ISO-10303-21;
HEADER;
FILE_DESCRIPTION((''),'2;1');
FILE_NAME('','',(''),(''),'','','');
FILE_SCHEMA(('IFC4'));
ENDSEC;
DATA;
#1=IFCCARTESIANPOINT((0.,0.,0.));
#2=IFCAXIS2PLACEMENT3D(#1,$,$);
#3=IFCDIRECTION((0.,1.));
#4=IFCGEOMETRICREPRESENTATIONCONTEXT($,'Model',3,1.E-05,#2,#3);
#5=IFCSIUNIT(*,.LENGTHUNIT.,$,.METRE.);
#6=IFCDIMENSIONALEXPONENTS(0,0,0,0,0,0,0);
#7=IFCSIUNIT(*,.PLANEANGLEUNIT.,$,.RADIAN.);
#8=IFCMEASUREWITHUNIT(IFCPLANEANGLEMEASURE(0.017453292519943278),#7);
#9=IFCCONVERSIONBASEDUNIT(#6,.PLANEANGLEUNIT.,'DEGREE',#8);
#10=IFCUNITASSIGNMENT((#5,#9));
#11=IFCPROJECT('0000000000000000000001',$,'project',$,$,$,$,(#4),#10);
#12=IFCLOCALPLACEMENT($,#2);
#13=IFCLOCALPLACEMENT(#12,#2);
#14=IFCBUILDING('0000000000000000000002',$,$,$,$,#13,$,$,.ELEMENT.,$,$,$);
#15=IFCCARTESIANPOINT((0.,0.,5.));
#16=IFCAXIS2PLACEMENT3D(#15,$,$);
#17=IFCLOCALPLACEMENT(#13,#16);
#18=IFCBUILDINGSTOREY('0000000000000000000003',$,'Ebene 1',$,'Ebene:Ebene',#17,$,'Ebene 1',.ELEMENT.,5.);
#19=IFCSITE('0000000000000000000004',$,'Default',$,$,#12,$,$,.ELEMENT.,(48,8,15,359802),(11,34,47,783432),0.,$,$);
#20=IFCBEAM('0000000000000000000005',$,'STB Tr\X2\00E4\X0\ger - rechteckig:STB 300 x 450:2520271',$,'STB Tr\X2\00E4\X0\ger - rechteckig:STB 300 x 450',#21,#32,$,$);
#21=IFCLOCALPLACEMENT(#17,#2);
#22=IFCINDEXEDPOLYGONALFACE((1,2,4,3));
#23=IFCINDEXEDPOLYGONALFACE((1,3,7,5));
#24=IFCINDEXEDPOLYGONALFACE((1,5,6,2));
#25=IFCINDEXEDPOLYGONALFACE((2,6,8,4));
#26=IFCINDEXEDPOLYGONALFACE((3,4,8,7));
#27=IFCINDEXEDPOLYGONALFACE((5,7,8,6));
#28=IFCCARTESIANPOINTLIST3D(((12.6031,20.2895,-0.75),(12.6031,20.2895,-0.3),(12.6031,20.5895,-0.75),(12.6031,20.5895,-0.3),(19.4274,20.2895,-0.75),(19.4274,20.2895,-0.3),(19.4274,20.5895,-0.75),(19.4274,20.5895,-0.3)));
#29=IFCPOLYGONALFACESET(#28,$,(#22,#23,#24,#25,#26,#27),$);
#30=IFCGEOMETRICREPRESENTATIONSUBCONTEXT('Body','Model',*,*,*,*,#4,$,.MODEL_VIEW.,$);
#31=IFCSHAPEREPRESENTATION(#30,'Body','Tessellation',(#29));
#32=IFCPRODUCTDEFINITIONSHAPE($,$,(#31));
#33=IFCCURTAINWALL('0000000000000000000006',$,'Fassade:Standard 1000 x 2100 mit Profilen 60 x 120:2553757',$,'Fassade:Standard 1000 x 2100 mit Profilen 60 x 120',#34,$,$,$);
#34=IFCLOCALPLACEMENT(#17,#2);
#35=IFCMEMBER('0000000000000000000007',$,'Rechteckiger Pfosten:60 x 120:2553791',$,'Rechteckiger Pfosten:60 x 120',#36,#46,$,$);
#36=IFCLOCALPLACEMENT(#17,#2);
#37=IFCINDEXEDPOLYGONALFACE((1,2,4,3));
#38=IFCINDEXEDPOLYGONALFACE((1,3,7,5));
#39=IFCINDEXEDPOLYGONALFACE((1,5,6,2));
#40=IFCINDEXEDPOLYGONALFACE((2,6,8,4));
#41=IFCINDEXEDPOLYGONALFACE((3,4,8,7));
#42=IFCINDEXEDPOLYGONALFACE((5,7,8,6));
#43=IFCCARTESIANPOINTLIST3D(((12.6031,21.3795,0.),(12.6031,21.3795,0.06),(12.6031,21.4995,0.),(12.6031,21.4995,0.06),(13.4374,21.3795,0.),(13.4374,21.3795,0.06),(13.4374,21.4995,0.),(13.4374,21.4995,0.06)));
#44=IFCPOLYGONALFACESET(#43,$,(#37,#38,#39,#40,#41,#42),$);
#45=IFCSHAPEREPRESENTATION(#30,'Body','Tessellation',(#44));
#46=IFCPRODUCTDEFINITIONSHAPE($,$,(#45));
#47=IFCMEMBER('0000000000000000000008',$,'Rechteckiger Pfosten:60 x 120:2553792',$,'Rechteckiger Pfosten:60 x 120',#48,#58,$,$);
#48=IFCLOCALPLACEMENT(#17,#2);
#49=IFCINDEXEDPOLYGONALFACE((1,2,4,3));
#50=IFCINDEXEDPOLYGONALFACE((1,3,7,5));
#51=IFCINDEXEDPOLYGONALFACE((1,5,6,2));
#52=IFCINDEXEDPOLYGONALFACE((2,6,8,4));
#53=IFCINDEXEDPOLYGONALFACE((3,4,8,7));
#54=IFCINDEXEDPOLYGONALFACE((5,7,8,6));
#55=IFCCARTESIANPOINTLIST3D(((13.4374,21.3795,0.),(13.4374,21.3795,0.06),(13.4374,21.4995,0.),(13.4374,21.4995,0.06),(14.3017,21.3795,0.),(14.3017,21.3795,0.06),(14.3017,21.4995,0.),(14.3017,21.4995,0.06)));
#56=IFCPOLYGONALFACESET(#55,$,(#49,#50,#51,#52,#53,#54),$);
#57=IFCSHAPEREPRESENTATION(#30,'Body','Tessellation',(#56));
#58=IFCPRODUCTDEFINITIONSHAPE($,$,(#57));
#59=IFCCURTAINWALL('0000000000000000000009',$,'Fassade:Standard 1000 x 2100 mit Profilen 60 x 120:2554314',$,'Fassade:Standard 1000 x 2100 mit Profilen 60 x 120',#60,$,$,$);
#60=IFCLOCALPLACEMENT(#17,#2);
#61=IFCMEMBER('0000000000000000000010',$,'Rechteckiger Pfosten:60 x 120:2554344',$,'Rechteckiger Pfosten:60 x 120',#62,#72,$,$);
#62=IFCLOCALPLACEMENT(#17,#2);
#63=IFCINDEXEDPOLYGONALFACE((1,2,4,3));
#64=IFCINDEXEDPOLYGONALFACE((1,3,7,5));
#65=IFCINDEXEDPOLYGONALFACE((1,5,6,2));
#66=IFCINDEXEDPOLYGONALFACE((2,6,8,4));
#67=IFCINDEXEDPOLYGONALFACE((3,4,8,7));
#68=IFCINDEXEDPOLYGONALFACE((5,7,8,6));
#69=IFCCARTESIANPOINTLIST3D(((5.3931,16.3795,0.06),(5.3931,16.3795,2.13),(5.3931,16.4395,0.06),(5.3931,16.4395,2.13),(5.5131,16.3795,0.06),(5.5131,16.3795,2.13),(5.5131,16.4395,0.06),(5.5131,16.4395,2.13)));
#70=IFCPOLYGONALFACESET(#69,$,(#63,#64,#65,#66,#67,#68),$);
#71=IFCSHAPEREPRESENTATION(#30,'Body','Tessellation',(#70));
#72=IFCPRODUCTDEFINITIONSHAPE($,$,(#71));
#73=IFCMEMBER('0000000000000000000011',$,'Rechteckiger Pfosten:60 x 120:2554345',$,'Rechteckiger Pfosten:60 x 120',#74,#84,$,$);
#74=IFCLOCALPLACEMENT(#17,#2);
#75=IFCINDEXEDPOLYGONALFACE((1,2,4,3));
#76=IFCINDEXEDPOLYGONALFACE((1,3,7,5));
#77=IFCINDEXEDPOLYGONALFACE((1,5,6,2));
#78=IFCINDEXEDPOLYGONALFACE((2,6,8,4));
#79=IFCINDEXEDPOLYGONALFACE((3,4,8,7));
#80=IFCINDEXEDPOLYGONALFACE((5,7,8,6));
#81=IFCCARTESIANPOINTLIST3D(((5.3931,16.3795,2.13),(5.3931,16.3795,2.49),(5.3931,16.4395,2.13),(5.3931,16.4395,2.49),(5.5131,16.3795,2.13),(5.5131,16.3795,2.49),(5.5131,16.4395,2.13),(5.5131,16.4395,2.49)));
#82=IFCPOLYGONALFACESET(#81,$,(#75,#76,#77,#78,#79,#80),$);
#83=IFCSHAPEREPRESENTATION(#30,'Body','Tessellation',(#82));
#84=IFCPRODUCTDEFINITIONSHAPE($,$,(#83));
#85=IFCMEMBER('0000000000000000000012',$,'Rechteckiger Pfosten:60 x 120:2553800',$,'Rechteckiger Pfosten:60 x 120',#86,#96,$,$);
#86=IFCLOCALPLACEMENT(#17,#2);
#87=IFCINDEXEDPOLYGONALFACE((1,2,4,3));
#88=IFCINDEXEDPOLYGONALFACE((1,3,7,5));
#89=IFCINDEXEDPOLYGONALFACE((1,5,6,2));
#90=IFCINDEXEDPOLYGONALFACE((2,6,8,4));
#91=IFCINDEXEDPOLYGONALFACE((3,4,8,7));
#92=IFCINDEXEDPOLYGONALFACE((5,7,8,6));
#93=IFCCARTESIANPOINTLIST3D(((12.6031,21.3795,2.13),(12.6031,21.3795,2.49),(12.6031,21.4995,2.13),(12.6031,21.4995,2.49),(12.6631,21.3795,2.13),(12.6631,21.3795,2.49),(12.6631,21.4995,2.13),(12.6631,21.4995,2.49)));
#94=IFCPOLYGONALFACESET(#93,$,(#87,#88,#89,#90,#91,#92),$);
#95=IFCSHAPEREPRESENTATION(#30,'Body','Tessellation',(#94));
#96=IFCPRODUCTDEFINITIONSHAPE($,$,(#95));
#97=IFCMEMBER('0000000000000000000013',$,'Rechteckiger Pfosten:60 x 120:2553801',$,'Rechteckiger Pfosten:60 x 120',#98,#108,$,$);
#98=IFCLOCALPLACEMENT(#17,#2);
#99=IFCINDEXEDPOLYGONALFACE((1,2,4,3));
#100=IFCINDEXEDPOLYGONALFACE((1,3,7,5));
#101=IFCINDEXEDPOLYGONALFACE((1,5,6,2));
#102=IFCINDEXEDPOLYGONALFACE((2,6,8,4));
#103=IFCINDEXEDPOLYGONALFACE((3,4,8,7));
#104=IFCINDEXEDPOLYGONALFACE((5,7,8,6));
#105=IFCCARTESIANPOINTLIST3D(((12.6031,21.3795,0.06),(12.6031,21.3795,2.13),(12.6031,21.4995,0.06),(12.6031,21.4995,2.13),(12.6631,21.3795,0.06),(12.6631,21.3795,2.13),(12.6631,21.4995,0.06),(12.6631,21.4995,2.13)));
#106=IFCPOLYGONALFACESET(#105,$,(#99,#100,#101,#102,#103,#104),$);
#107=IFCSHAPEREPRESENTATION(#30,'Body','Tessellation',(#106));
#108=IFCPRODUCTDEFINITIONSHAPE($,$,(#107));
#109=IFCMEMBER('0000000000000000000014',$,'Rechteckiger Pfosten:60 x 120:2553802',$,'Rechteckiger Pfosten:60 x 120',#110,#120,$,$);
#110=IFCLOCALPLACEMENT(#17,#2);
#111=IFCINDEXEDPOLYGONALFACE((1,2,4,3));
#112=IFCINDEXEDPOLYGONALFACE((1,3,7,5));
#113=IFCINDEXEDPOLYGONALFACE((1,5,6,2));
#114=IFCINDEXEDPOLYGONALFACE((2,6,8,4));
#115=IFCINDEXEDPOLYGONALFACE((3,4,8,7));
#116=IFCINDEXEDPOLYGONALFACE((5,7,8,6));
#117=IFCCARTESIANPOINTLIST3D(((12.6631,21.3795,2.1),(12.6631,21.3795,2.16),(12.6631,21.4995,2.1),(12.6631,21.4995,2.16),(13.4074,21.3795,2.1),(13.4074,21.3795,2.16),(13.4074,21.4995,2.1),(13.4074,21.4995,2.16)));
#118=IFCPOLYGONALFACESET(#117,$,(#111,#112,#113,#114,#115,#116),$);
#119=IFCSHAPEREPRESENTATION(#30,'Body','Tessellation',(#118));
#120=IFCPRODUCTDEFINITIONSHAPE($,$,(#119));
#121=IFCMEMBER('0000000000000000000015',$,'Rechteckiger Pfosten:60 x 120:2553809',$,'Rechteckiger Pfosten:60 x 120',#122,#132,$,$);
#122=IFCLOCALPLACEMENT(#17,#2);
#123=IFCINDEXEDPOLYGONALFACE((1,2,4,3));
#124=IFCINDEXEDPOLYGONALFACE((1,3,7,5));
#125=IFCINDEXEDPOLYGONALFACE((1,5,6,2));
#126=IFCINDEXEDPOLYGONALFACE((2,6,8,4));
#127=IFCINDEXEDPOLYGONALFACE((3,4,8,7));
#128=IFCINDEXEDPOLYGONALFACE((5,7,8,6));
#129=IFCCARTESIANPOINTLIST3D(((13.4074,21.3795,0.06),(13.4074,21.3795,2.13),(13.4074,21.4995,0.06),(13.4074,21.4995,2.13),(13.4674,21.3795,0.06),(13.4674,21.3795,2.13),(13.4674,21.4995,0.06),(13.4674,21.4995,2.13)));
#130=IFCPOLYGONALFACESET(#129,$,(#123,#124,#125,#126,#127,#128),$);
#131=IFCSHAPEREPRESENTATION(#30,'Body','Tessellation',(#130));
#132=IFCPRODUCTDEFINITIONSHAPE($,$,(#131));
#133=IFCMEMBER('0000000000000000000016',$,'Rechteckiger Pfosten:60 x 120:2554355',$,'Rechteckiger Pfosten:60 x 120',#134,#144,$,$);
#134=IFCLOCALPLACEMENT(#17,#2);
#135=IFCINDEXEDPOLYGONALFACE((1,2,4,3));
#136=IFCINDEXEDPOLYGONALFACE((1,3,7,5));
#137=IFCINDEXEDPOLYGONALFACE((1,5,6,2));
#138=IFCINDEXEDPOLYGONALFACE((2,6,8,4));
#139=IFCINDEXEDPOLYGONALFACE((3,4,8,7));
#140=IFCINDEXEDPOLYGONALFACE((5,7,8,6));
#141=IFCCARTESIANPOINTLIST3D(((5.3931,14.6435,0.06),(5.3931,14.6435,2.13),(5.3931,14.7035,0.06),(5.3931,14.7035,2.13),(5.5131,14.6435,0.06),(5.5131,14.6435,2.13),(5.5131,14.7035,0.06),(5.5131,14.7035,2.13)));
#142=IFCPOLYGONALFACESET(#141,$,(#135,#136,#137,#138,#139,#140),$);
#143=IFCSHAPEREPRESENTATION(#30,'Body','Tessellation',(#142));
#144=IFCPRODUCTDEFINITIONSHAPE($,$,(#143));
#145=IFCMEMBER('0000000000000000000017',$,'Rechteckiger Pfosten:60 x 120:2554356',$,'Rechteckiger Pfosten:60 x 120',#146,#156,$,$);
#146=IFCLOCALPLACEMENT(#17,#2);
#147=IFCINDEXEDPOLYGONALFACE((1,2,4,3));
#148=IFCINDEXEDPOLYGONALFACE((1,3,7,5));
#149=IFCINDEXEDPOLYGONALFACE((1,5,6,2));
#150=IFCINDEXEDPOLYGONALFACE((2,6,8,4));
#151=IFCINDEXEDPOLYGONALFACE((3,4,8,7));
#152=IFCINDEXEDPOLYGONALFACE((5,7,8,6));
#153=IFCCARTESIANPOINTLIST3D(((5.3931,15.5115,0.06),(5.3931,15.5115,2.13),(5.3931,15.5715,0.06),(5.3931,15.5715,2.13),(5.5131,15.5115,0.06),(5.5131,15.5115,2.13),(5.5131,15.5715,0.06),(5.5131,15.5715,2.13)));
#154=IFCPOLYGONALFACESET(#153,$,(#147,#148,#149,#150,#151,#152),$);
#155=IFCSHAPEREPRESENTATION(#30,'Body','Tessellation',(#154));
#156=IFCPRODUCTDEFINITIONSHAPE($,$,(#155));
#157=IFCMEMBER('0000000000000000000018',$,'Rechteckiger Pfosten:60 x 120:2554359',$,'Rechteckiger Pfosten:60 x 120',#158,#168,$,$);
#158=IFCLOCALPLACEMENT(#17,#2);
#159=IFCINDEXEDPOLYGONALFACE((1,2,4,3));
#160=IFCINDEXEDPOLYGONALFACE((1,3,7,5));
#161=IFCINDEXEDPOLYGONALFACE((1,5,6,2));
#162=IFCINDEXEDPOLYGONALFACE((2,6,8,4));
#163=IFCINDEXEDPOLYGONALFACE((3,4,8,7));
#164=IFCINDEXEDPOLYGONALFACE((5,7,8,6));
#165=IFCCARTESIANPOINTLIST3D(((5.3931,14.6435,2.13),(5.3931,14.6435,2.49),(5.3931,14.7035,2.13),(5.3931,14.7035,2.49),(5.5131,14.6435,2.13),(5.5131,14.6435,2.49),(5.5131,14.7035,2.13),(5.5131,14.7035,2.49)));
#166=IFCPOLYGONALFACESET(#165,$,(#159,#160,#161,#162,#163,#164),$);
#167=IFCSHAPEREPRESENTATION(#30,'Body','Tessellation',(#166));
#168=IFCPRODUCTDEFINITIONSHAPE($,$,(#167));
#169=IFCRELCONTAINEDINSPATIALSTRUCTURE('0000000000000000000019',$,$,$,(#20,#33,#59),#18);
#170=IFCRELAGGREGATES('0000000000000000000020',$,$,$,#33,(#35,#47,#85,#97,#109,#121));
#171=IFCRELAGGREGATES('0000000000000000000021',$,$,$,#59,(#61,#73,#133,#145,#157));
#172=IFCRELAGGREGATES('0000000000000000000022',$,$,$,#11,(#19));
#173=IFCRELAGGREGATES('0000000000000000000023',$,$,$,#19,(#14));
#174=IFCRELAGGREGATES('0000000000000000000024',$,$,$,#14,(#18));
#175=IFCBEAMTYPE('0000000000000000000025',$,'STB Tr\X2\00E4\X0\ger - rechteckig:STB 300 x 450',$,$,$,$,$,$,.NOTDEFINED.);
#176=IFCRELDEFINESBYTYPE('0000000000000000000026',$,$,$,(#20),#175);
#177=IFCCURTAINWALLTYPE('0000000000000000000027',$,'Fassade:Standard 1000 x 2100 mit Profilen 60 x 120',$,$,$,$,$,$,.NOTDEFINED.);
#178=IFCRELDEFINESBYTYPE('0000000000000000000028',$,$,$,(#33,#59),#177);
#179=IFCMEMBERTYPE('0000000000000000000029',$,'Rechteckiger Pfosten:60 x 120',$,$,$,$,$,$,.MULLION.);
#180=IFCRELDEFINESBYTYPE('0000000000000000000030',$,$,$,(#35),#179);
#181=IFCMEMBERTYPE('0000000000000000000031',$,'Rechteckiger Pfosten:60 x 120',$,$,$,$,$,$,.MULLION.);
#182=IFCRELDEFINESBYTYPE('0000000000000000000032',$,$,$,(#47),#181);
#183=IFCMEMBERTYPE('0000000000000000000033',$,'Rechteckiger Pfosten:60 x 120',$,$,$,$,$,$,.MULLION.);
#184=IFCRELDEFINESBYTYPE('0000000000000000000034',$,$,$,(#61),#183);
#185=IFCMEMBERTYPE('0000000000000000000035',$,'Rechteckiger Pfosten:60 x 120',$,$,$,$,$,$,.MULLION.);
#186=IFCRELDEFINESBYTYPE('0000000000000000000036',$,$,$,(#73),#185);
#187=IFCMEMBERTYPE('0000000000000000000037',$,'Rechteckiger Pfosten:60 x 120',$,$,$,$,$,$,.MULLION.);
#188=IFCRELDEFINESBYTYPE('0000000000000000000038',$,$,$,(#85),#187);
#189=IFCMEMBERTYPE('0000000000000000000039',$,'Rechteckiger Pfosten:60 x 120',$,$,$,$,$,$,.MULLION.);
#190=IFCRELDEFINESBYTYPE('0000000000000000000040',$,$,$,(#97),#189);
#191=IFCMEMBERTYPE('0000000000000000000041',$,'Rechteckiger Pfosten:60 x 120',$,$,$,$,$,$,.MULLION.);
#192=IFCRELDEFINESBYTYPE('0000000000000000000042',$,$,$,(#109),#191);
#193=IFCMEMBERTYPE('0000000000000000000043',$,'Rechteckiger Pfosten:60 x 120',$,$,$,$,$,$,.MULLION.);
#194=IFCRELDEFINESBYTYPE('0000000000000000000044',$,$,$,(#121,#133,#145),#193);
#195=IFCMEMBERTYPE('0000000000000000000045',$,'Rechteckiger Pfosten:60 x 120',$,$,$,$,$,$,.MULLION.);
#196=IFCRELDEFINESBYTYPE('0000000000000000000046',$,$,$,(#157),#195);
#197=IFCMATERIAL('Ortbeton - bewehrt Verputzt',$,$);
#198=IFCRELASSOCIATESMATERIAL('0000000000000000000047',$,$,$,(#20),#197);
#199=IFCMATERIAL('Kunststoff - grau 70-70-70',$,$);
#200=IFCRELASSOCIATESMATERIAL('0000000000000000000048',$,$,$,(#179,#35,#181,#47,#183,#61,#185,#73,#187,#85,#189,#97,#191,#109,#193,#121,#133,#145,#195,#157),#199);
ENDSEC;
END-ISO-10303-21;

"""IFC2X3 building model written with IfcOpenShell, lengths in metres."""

from ifc_helpers import new_model, entity, si_unit, converted_unit, direction, frame, frame_2d, origin, origin_2d_with_axis, place, context, subcontext, project, spatial, rectangle, extrude, source, transform, mapped, material, type_object, type_shapes, element, aggregate, save


model = new_model("IFC2X3")

# Units and contexts
model_context = context("Model", 3, precision=1e-05, world=origin(), true_north=direction((0.0, 1.0)))
body_context = subcontext(model_context, "Body", "Model", "MODEL_VIEW")
ifc_project = project(units=[si_unit("LENGTHUNIT", "METRE"), converted_unit("PLANEANGLEUNIT", "DEGREE", entity("IfcPlaneAngleMeasure", 0.017453292519943278), si_unit("PLANEANGLEUNIT", "RADIAN"), dimensions=[0, 0, 0, 0, 0, 0, 0])], contexts=[model_context])

# Site, building, storey
site_placement = place(None, origin())
site = spatial("IfcSite", under=ifc_project, at=site_placement, Name="Default", CompositionType="ELEMENT", RefLatitude=(48, 8, 15, 359802), RefLongitude=(11, 34, 47, 783432), RefElevation=0.0)
building_placement = place(site_placement, origin())
building = spatial("IfcBuilding", under=site, at=building_placement, CompositionType="ELEMENT")
storey_placement = place(building_placement, frame((0.0, 0.0, 5.0)))
storey = spatial("IfcBuildingStorey", under=building, at=storey_placement, Name="Ebene 1", ObjectType="Ebene:Ebene", LongName="Ebene 1", CompositionType="ELEMENT", Elevation=5.0)

# Beam
ifc_material_1 = material(Name="Ortbeton - bewehrt Verputzt")
beam_type = type_object("IfcBeamType", Name="STB Träger - rechteckig:STB 300 x 450", PredefinedType="NOTDEFINED")
beam_1_placement = place(storey_placement, frame((12.4531, 20.4395, 0.0)))
element("IfcBeam", 1, at=beam_1_placement, inside=storey, type_object=beam_type, material=ifc_material_1, Name="STB Träger - rechteckig:STB 300 x 450:2520271", ObjectType="STB Träger - rechteckig:STB 300 x 450", context=body_context, shape_type="SweptSolid", body=[
    extrude(rectangle(XDim=0.45, YDim=0.3, at=frame_2d((0.0, 0.0), x_axis=(1.0, 0.0))), frame((0.15, 0.0, -0.525), z_axis=(1.0, 0.0, 0.0), x_axis=(0.0, 0.0, -1.0)), (0.0, 0.0, 1.0), 6.8243),
])

# Curtain walls, members
curtain_wall_type = type_object("IfcCurtainWallType", Name="Fassade:Standard 1000 x 2100 mit Profilen 60 x 120", PredefinedType="NOTDEFINED")
curtain_wall_1_placement = place(storey_placement, frame((0.0, 0.0, -5.0)))
curtain_wall_1 = element("IfcCurtainWall", 2, at=curtain_wall_1_placement, inside=storey, type_object=curtain_wall_type, Name="Fassade:Standard 1000 x 2100 mit Profilen 60 x 120:2553757", ObjectType="Fassade:Standard 1000 x 2100 mit Profilen 60 x 120")
ifc_material_2 = material(Name="Kunststoff - grau 70-70-70")
member_type_1 = type_object("IfcMemberType", Name="Rechteckiger Pfosten:60 x 120", PredefinedType="MULLION", material=ifc_material_2)
shared_shape_1 = source(origin(), body_context, "Body", "SweptSolid", [
    extrude(rectangle(XDim=0.06, YDim=0.12, at=origin_2d_with_axis()), frame((-0.03, 0.0, -0.8343), z_axis=(0.0, 0.0, 1.0), x_axis=(-1.0, 0.0, 0.0)), (0.0, 0.0, 1.0), 0.8343),
])
type_shapes(member_type_1, [shared_shape_1])
member_1_placement = place(curtain_wall_1_placement, frame((12.6031, 21.4395, 5.0), z_axis=(-1.0, 0.0, 0.0), x_axis=(0.0, 0.0, -1.0)))
member_1 = element("IfcMember", 3, at=member_1_placement, type_object=member_type_1, material=ifc_material_2, Name="Rechteckiger Pfosten:60 x 120:2553791", ObjectType="Rechteckiger Pfosten:60 x 120", context=body_context, shape_type="MappedRepresentation", body=[
    mapped(shared_shape_1, transform((0.0, 0.0, 0.0), scale=1.0)),
])
member_type_2 = type_object("IfcMemberType", Name="Rechteckiger Pfosten:60 x 120", PredefinedType="MULLION", material=ifc_material_2)
shared_shape_2 = source(origin(), body_context, "Body", "SweptSolid", [
    extrude(rectangle(XDim=0.06, YDim=0.12, at=origin_2d_with_axis()), frame((-0.03, 0.0, -0.8643), z_axis=(0.0, 0.0, 1.0), x_axis=(-1.0, 0.0, 0.0)), (0.0, 0.0, 1.0), 0.8643),
])
type_shapes(member_type_2, [shared_shape_2])
member_2_placement = place(curtain_wall_1_placement, frame((13.4374, 21.4395, 5.0), z_axis=(-1.0, 0.0, 0.0), x_axis=(0.0, 0.0, -1.0)))
member_2 = element("IfcMember", 4, at=member_2_placement, type_object=member_type_2, material=ifc_material_2, Name="Rechteckiger Pfosten:60 x 120:2553792", ObjectType="Rechteckiger Pfosten:60 x 120", context=body_context, shape_type="MappedRepresentation", body=[
    mapped(shared_shape_2, transform((0.0, 0.0, 0.0), scale=1.0)),
])
curtain_wall_2_placement = place(storey_placement, frame((0.0, 0.0, -5.0)))
curtain_wall_2 = element("IfcCurtainWall", 5, at=curtain_wall_2_placement, inside=storey, type_object=curtain_wall_type, Name="Fassade:Standard 1000 x 2100 mit Profilen 60 x 120:2554314", ObjectType="Fassade:Standard 1000 x 2100 mit Profilen 60 x 120")
member_type_3 = type_object("IfcMemberType", Name="Rechteckiger Pfosten:60 x 120", PredefinedType="MULLION", material=ifc_material_2)
shared_shape_3 = source(origin(), body_context, "Body", "SweptSolid", [
    extrude(rectangle(XDim=0.06, YDim=0.12, at=origin_2d_with_axis()), frame((-0.03, 0.0, -2.07), z_axis=(0.0, 0.0, 1.0), x_axis=(-1.0, 0.0, 0.0)), (0.0, 0.0, 1.0), 2.07),
])
type_shapes(member_type_3, [shared_shape_3])
member_3_placement = place(curtain_wall_2_placement, frame((5.4531, 16.4395, 5.06), z_axis=(0.0, 0.0, -1.0), x_axis=(0.0, 1.0, 0.0)))
member_3 = element("IfcMember", 6, at=member_3_placement, type_object=member_type_3, material=ifc_material_2, Name="Rechteckiger Pfosten:60 x 120:2554344", ObjectType="Rechteckiger Pfosten:60 x 120", context=body_context, shape_type="MappedRepresentation", body=[
    mapped(shared_shape_3, transform((0.0, 0.0, 0.0), scale=1.0)),
])
member_type_4 = type_object("IfcMemberType", Name="Rechteckiger Pfosten:60 x 120", PredefinedType="MULLION", material=ifc_material_2)
shared_shape_4 = source(origin(), body_context, "Body", "SweptSolid", [
    extrude(rectangle(XDim=0.06, YDim=0.12, at=origin_2d_with_axis()), frame((-0.03, 0.0, -0.36), z_axis=(0.0, 0.0, 1.0), x_axis=(-1.0, 0.0, 0.0)), (0.0, 0.0, 1.0), 0.36),
])
type_shapes(member_type_4, [shared_shape_4])
member_4_placement = place(curtain_wall_2_placement, frame((5.4531, 16.4395, 7.13), z_axis=(0.0, 0.0, -1.0), x_axis=(0.0, 1.0, 0.0)))
member_4 = element("IfcMember", 7, at=member_4_placement, type_object=member_type_4, material=ifc_material_2, Name="Rechteckiger Pfosten:60 x 120:2554345", ObjectType="Rechteckiger Pfosten:60 x 120", context=body_context, shape_type="MappedRepresentation", body=[
    mapped(shared_shape_4, transform((0.0, 0.0, 0.0), scale=1.0)),
])

# Members
member_type_5 = type_object("IfcMemberType", Name="Rechteckiger Pfosten:60 x 120", PredefinedType="MULLION", material=ifc_material_2)
shared_shape_5 = source(origin(), body_context, "Body", "SweptSolid", [
    extrude(rectangle(XDim=0.06, YDim=0.12, at=origin_2d_with_axis()), frame((-0.03, 0.0, -0.36), z_axis=(0.0, 0.0, 1.0), x_axis=(-1.0, 0.0, 0.0)), (0.0, 0.0, 1.0), 0.36),
])
type_shapes(member_type_5, [shared_shape_5])
member_5_placement = place(curtain_wall_1_placement, frame((12.6031, 21.4395, 7.49), z_axis=(0.0, 0.0, 1.0), x_axis=(-1.0, 0.0, 0.0)))
member_5 = element("IfcMember", 8, at=member_5_placement, type_object=member_type_5, material=ifc_material_2, Name="Rechteckiger Pfosten:60 x 120:2553800", ObjectType="Rechteckiger Pfosten:60 x 120", context=body_context, shape_type="MappedRepresentation", body=[
    mapped(shared_shape_5, transform((0.0, 0.0, 0.0), scale=1.0)),
])
member_type_6 = type_object("IfcMemberType", Name="Rechteckiger Pfosten:60 x 120", PredefinedType="MULLION", material=ifc_material_2)
shared_shape_6 = source(origin(), body_context, "Body", "SweptSolid", [
    extrude(rectangle(XDim=0.06, YDim=0.12, at=origin_2d_with_axis()), frame((-0.03, 0.0, -2.07), z_axis=(0.0, 0.0, 1.0), x_axis=(-1.0, 0.0, 0.0)), (0.0, 0.0, 1.0), 2.07),
])
type_shapes(member_type_6, [shared_shape_6])
member_6_placement = place(curtain_wall_1_placement, frame((12.6031, 21.4395, 7.13), z_axis=(0.0, 0.0, 1.0), x_axis=(-1.0, 0.0, 0.0)))
member_6 = element("IfcMember", 9, at=member_6_placement, type_object=member_type_6, material=ifc_material_2, Name="Rechteckiger Pfosten:60 x 120:2553801", ObjectType="Rechteckiger Pfosten:60 x 120", context=body_context, shape_type="MappedRepresentation", body=[
    mapped(shared_shape_6, transform((0.0, 0.0, 0.0), scale=1.0)),
])
member_type_7 = type_object("IfcMemberType", Name="Rechteckiger Pfosten:60 x 120", PredefinedType="MULLION", material=ifc_material_2)
shared_shape_7 = source(origin(), body_context, "Body", "SweptSolid", [
    extrude(rectangle(XDim=0.06, YDim=0.12, at=frame_2d((0.0, 0.0), x_axis=(1.0, 0.0))), frame((0.0, 0.0, -0.7443), z_axis=(0.0, 0.0, 1.0), x_axis=(-1.0, 0.0, 0.0)), (0.0, 0.0, 1.0), 0.7443),
])
type_shapes(member_type_7, [shared_shape_7])
member_7_placement = place(curtain_wall_1_placement, frame((13.4074, 21.4395, 7.13), z_axis=(1.0, 0.0, 0.0), x_axis=(0.0, 0.0, 1.0)))
member_7 = element("IfcMember", 10, at=member_7_placement, type_object=member_type_7, material=ifc_material_2, Name="Rechteckiger Pfosten:60 x 120:2553802", ObjectType="Rechteckiger Pfosten:60 x 120", context=body_context, shape_type="MappedRepresentation", body=[
    mapped(shared_shape_7, transform((0.0, 0.0, 0.0), scale=1.0)),
])
member_type_8 = type_object("IfcMemberType", Name="Rechteckiger Pfosten:60 x 120", PredefinedType="MULLION", material=ifc_material_2)
shared_shape_8 = source(origin(), body_context, "Body", "SweptSolid", [
    extrude(rectangle(XDim=0.06, YDim=0.12, at=origin_2d_with_axis()), frame((0.0, 0.0, -2.07), z_axis=(0.0, 0.0, 1.0), x_axis=(-1.0, 0.0, 0.0)), (0.0, 0.0, 1.0), 2.07),
])
type_shapes(member_type_8, [shared_shape_8])
member_8_placement = place(curtain_wall_1_placement, frame((13.4374, 21.4395, 5.06), z_axis=(0.0, 0.0, -1.0), x_axis=(1.0, 0.0, 0.0)))
member_8 = element("IfcMember", 11, at=member_8_placement, type_object=member_type_8, material=ifc_material_2, Name="Rechteckiger Pfosten:60 x 120:2553809", ObjectType="Rechteckiger Pfosten:60 x 120", context=body_context, shape_type="MappedRepresentation", body=[
    mapped(shared_shape_8, transform((0.0, 0.0, 0.0), scale=1.0)),
])
member_9_placement = place(curtain_wall_2_placement, frame((5.4531, 14.6735, 5.06), z_axis=(0.0, 0.0, -1.0), x_axis=(0.0, 1.0, 0.0)))
member_9 = element("IfcMember", 12, at=member_9_placement, type_object=member_type_8, material=ifc_material_2, Name="Rechteckiger Pfosten:60 x 120:2554355", ObjectType="Rechteckiger Pfosten:60 x 120", context=body_context, shape_type="MappedRepresentation", body=[
    mapped(shared_shape_8, transform((0.0, 0.0, 0.0), scale=1.0)),
])
member_10_placement = place(curtain_wall_2_placement, frame((5.4531, 15.5415, 5.06), z_axis=(0.0, 0.0, -1.0), x_axis=(0.0, 1.0, 0.0)))
member_10 = element("IfcMember", 13, at=member_10_placement, type_object=member_type_8, material=ifc_material_2, Name="Rechteckiger Pfosten:60 x 120:2554356", ObjectType="Rechteckiger Pfosten:60 x 120", context=body_context, shape_type="MappedRepresentation", body=[
    mapped(shared_shape_8, transform((0.0, 0.0, 0.0), scale=1.0)),
])
member_type_9 = type_object("IfcMemberType", Name="Rechteckiger Pfosten:60 x 120", PredefinedType="MULLION", material=ifc_material_2)
shared_shape_9 = source(origin(), body_context, "Body", "SweptSolid", [
    extrude(rectangle(XDim=0.06, YDim=0.12, at=frame_2d((0.0, 0.0), x_axis=(1.0, 0.0))), frame((0.0, 0.0, -0.36), z_axis=(0.0, 0.0, 1.0), x_axis=(-1.0, 0.0, 0.0)), (0.0, 0.0, 1.0), 0.36),
])
type_shapes(member_type_9, [shared_shape_9])
member_11_placement = place(curtain_wall_2_placement, frame((5.4531, 14.6735, 7.13), z_axis=(0.0, 0.0, -1.0), x_axis=(0.0, 1.0, 0.0)))
member_11 = element("IfcMember", 14, at=member_11_placement, type_object=member_type_9, material=ifc_material_2, Name="Rechteckiger Pfosten:60 x 120:2554359", ObjectType="Rechteckiger Pfosten:60 x 120", context=body_context, shape_type="MappedRepresentation", body=[
    mapped(shared_shape_9, transform((0.0, 0.0, 0.0), scale=1.0)),
])

aggregate(curtain_wall_1, [member_1, member_2, member_5, member_6, member_7, member_8])
aggregate(curtain_wall_2, [member_3, member_4, member_9, member_10, member_11])

save(model, "model.ifc")
